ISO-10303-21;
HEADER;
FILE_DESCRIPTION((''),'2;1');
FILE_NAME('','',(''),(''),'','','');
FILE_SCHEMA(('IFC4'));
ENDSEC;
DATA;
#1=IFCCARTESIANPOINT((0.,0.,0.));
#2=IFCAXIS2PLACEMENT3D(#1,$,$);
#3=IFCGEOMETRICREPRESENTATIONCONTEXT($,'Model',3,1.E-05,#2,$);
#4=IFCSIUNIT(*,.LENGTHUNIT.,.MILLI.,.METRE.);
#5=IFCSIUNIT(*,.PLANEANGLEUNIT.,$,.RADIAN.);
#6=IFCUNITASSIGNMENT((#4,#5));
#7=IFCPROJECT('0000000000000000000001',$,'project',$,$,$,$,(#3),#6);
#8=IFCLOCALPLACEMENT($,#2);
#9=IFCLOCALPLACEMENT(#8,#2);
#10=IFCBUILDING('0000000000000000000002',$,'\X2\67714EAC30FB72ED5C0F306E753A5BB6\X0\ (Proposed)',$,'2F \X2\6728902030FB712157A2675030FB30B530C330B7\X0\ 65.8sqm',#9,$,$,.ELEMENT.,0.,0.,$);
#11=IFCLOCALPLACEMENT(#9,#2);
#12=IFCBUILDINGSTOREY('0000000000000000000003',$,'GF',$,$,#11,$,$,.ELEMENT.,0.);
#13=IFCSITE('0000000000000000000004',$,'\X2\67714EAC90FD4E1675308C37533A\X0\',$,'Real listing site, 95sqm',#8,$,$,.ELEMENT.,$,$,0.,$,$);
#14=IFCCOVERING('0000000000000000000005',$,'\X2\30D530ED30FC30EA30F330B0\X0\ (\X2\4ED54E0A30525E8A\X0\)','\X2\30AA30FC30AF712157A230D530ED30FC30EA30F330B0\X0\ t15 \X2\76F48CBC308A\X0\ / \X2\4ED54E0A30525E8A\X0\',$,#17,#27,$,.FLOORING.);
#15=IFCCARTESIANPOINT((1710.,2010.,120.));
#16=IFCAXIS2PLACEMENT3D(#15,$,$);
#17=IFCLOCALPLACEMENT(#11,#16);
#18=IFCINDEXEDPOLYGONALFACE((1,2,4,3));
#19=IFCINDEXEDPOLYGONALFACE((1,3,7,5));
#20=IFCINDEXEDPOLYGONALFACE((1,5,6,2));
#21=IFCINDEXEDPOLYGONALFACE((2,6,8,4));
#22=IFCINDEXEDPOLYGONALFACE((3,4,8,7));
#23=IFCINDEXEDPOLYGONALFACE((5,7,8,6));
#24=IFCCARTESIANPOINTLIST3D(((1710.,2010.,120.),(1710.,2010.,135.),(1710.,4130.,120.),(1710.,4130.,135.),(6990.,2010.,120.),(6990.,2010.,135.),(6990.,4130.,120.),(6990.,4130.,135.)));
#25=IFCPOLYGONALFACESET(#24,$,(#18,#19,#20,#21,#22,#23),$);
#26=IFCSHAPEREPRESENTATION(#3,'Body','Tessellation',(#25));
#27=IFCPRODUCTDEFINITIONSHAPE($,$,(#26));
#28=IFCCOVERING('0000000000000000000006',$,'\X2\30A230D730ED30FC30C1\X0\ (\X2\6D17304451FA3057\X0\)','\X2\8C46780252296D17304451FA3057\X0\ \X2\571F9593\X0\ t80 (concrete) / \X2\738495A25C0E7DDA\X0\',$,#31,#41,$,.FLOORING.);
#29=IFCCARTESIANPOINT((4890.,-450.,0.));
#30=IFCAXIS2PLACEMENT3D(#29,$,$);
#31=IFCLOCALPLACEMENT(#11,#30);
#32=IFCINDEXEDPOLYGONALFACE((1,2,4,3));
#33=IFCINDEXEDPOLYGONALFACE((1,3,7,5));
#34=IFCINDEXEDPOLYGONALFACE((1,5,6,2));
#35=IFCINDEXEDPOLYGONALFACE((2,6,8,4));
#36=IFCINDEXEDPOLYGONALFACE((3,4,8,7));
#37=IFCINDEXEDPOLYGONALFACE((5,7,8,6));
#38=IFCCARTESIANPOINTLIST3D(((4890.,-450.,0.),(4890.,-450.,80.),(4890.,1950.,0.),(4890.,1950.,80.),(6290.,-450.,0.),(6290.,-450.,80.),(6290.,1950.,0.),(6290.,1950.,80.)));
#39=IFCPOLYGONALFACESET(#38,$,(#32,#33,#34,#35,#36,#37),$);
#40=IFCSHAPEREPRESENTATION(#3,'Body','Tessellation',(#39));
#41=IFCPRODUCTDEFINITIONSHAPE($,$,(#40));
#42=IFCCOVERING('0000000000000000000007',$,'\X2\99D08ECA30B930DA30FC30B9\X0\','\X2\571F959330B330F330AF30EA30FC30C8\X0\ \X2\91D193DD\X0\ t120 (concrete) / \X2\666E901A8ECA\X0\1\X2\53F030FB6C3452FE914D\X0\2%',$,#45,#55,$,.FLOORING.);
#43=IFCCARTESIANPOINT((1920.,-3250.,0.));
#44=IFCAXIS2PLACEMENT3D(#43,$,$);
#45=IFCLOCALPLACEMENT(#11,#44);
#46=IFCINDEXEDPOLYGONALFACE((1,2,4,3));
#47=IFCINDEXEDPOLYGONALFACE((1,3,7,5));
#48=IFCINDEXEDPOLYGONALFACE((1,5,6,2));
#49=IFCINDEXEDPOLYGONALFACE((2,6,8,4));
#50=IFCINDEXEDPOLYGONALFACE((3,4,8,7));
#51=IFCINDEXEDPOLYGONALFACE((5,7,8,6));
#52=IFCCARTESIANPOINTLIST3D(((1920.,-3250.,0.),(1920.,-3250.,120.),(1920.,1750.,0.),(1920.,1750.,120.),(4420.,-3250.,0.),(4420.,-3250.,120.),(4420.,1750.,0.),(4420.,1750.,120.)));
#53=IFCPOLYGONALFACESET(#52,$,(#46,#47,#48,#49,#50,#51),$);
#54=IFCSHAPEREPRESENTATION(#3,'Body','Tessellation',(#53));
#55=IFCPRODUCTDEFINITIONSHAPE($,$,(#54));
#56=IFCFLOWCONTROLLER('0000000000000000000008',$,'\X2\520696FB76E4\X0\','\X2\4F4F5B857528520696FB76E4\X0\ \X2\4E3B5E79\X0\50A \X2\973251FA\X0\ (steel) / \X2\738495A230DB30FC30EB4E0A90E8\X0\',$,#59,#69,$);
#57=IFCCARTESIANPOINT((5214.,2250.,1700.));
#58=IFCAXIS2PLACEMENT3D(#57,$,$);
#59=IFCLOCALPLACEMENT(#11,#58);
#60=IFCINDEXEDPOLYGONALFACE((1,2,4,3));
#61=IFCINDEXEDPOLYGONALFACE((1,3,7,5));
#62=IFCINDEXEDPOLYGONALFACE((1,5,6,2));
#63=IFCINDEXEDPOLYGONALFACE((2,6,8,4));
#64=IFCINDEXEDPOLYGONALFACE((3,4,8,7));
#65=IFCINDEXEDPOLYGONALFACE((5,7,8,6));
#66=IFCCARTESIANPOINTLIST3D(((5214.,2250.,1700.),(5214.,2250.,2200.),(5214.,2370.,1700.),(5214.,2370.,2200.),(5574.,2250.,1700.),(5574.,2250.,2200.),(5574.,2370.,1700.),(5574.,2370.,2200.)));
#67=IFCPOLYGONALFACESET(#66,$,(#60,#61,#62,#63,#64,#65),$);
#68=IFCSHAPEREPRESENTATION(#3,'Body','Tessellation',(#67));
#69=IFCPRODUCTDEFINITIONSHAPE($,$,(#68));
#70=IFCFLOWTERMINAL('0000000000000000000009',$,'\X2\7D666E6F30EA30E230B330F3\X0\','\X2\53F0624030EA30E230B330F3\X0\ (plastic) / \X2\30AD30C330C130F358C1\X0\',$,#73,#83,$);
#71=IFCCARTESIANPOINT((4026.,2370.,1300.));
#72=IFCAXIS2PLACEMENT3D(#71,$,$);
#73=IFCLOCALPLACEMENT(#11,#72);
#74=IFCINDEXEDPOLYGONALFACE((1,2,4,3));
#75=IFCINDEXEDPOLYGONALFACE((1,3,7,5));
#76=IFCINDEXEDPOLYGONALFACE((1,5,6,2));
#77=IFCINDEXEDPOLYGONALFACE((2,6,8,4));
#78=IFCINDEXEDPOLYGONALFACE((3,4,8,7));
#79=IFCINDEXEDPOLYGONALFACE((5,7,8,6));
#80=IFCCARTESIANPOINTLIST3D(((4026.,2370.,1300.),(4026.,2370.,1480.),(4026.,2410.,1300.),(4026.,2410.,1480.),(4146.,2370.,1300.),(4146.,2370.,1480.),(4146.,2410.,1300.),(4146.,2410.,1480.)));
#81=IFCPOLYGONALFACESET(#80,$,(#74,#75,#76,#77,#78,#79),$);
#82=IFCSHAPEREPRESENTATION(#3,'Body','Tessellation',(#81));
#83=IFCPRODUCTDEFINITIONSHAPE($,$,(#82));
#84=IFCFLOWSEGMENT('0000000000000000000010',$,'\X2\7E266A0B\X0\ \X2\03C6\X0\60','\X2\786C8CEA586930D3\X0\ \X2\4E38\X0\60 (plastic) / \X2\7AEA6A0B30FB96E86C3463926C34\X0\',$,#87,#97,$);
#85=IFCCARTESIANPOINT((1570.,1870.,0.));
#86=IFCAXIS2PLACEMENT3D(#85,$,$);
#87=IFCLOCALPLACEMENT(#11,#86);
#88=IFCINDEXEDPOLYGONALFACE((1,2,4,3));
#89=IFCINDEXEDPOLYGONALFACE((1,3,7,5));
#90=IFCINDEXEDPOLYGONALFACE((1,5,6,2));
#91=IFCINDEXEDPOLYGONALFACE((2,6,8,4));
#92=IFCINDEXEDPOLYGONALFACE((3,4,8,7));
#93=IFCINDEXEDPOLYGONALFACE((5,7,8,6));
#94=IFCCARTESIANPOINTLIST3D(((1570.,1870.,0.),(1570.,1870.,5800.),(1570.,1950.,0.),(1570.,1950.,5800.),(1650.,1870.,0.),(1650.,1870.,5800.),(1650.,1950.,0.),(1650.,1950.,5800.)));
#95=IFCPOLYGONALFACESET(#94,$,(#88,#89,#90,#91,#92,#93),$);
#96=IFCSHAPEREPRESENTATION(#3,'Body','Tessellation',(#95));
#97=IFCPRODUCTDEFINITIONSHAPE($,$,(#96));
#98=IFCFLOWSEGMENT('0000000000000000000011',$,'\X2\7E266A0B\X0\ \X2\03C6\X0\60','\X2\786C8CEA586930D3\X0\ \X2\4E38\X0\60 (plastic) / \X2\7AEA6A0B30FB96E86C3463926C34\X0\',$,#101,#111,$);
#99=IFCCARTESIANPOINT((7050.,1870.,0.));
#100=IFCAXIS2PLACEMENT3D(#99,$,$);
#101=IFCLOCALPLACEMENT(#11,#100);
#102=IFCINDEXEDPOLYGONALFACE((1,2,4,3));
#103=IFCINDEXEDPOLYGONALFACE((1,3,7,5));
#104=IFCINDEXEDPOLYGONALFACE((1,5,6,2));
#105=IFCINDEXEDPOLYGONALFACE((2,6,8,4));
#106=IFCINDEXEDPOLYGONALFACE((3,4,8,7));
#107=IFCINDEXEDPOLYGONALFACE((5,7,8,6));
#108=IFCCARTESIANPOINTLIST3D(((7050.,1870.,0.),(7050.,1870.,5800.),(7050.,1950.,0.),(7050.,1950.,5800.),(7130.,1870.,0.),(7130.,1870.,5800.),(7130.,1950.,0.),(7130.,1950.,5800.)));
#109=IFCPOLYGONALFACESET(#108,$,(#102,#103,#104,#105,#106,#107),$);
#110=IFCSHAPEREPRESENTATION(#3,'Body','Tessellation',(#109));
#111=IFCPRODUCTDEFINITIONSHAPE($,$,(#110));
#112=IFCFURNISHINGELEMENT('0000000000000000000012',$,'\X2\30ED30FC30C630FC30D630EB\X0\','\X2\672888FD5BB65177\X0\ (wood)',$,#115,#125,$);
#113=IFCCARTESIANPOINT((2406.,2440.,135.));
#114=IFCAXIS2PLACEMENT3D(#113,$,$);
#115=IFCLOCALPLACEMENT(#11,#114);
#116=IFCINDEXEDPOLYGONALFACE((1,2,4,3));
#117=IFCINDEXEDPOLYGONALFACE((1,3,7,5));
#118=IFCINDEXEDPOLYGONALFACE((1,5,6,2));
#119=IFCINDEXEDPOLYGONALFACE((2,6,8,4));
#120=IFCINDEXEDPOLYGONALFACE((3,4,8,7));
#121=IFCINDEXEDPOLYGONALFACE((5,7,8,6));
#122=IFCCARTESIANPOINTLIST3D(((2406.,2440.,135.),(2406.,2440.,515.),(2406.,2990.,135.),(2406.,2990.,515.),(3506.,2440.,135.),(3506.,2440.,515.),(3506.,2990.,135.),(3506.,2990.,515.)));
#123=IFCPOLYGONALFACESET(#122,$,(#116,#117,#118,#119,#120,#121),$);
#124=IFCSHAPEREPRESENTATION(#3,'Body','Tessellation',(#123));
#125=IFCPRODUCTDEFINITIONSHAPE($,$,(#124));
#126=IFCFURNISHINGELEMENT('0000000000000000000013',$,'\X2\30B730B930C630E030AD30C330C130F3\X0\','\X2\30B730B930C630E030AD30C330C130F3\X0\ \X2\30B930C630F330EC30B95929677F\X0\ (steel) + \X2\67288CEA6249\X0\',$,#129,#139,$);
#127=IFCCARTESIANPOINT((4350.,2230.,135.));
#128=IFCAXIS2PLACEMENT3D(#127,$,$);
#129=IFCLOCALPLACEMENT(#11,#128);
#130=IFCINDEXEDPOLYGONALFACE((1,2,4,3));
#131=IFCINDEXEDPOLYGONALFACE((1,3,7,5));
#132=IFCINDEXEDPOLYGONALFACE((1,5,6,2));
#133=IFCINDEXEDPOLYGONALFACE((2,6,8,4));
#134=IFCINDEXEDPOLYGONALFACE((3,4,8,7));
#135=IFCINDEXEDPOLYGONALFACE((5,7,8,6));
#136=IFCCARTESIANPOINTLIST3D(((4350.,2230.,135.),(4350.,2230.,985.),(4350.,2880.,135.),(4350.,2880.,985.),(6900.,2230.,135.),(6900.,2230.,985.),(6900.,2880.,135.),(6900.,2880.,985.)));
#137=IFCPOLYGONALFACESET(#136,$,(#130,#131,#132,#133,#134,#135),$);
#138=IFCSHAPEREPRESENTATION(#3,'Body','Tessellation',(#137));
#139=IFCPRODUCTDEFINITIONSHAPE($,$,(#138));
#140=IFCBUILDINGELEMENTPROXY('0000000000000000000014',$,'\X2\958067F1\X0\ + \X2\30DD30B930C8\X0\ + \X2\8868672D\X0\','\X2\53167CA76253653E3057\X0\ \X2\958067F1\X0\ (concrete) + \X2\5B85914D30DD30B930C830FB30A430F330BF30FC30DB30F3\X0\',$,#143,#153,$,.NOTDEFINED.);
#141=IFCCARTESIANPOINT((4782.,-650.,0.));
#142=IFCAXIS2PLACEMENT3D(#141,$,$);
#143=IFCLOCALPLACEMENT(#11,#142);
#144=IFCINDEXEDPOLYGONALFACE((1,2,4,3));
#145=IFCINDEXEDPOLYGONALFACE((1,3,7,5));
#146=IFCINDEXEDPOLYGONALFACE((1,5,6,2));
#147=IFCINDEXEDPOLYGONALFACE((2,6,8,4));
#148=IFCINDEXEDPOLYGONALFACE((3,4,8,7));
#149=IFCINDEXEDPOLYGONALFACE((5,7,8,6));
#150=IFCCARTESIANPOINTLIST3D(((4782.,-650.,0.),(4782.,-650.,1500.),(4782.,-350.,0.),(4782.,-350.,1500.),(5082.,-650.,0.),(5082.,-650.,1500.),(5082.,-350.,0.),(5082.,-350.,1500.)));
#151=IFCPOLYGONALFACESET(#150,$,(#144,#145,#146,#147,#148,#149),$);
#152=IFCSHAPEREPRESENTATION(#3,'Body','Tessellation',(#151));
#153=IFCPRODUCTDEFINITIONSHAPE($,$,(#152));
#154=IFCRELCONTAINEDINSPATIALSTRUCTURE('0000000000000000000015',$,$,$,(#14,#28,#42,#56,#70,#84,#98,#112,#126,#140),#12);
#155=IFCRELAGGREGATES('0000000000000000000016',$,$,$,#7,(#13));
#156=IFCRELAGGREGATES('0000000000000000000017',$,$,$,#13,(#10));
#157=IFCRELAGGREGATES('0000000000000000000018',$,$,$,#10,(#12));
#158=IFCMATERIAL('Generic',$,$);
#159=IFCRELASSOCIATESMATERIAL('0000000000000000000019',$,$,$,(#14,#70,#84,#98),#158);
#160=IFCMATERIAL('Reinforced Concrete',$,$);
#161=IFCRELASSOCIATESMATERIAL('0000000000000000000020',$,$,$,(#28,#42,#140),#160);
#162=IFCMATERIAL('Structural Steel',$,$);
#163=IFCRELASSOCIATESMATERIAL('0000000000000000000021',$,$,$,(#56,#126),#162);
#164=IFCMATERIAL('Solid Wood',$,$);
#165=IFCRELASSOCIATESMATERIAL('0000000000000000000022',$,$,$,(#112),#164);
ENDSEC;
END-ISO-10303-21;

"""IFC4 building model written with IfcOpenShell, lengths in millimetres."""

from ifc_helpers import new_model, si_unit, frame, frame_2d, origin, place, context, project, spatial, rectangle, extrude, material, element, save


model = new_model("IFC4")

# Units and contexts
model_context = context("Model", 3, precision=1e-05, world=origin())
ifc_project = project(units=[si_unit("LENGTHUNIT", "METRE", prefix="MILLI"), si_unit("PLANEANGLEUNIT", "RADIAN")], contexts=[model_context])

# Site, building, storey
site_placement = place(None, origin())
site = spatial("IfcSite", under=ifc_project, at=site_placement, Name="東京都世田谷区", ObjectType="Real listing site, 95sqm", CompositionType="ELEMENT", RefElevation=0.0)
building_placement = place(site_placement, origin())
building = spatial("IfcBuilding", under=site, at=building_placement, Name="東京・狭小の町家 (Proposed)", ObjectType="2F 木造・無垢材・サッシ 65.8sqm", CompositionType="ELEMENT", ElevationOfRefHeight=0.0, ElevationOfTerrain=0.0)
storey_placement = place(building_placement, origin())
storey = spatial("IfcBuildingStorey", under=building, at=storey_placement, Name="GF", CompositionType="ELEMENT", Elevation=0.0)

# Shared definitions
ifc_material_1 = material(Name="Solid Wood")

# Shared definitions
ifc_material_2 = material(Name="Reinforced Concrete")

# Coverings
ifc_material_3 = material(Name="Generic")
covering_1_placement = place(storey_placement, frame((1710.0, 2010.0, 120.0)))
element("IfcCovering", 1, at=covering_1_placement, inside=storey, material=ifc_material_3, Name="フローリング (仕上げ床)", Description="オーク無垢フローリング t15 直貼り / 仕上げ床", PredefinedType="FLOORING", context=model_context, shape_type="SweptSolid", body=[
    extrude(rectangle(XDim=5280.0, YDim=2120.0, at=frame_2d((2640.0, 1060.0))), frame((1710.0, 2010.0, 120.0)), (0.0, 0.0, 1.0), 15.0),
])
covering_2_placement = place(storey_placement, frame((4890.0, -450.0, 0.0)))
element("IfcCovering", 2, at=covering_2_placement, inside=storey, material=ifc_material_2, Name="アプローチ (洗い出し)", Description="豆砂利洗い出し 土間 t80 (concrete) / 玄関導線", PredefinedType="FLOORING", context=model_context, shape_type="SweptSolid", body=[
    extrude(rectangle(XDim=1400.0, YDim=2400.0, at=frame_2d((700.0, 1200.0))), frame((4890.0, -450.0, 0.0)), (0.0, 0.0, 1.0), 80.0),
])
covering_3_placement = place(storey_placement, frame((1920.0, -3250.0, 0.0)))
element("IfcCovering", 3, at=covering_3_placement, inside=storey, material=ifc_material_2, Name="駐車スペース", Description="土間コンクリート 金鏝 t120 (concrete) / 普通車1台・水勾配2%", PredefinedType="FLOORING", context=model_context, shape_type="SweptSolid", body=[
    extrude(rectangle(XDim=2500.0, YDim=5000.0, at=frame_2d((1250.0, 2500.0))), frame((1920.0, -3250.0, 0.0)), (0.0, 0.0, 1.0), 120.0),
])

# Flow controller
ifc_material_4 = material(Name="Structural Steel")
flow_controller_placement = place(storey_placement, frame((5214.0, 2250.0, 1700.0)))
element("IfcFlowController", 4, at=flow_controller_placement, inside=storey, material=ifc_material_4, Name="分電盤", Description="住宅用分電盤 主幹50A 露出 (steel) / 玄関ホール上部", context=model_context, shape_type="SweptSolid", body=[
    extrude(rectangle(XDim=360.0, YDim=120.0, at=frame_2d((180.0, 60.0))), frame((5214.0, 2250.0, 1700.0)), (0.0, 0.0, 1.0), 500.0),
])

# Flow terminal
flow_terminal_placement = place(storey_placement, frame((4026.0, 2370.0, 1300.0)))
element("IfcFlowTerminal", 5, at=flow_terminal_placement, inside=storey, material=ifc_material_3, Name="給湯リモコン", Description="台所リモコン (plastic) / キッチン壁", context=model_context, shape_type="SweptSolid", body=[
    extrude(rectangle(XDim=120.0, YDim=40.0, at=frame_2d((60.0, 20.0))), frame((4026.0, 2370.0, 1300.0)), (0.0, 0.0, 1.0), 180.0),
])

# Flow segments
flow_segment_1_placement = place(storey_placement, frame((1570.0, 1870.0, 0.0)))
element("IfcFlowSegment", 6, at=flow_segment_1_placement, inside=storey, material=ifc_material_3, Name="縦樋 φ60", Description="硬質塩ビ 丸60 (plastic) / 竪樋・雨水排水", context=model_context, shape_type="SweptSolid", body=[
    extrude(rectangle(XDim=80.0, YDim=80.0, at=frame_2d((40.0, 40.0))), frame((1570.0, 1870.0, 0.0)), (0.0, 0.0, 1.0), 5800.0),
])
flow_segment_2_placement = place(storey_placement, frame((7050.0, 1870.0, 0.0)))
element("IfcFlowSegment", 7, at=flow_segment_2_placement, inside=storey, material=ifc_material_3, Name="縦樋 φ60", Description="硬質塩ビ 丸60 (plastic) / 竪樋・雨水排水", context=model_context, shape_type="SweptSolid", body=[
    extrude(rectangle(XDim=80.0, YDim=80.0, at=frame_2d((40.0, 40.0))), frame((7050.0, 1870.0, 0.0)), (0.0, 0.0, 1.0), 5800.0),
])

# Furnishing elements
furnishing_1_placement = place(storey_placement, frame((2406.0, 2440.0, 135.0)))
element("IfcFurnishingElement", 8, at=furnishing_1_placement, inside=storey, material=ifc_material_1, Name="ローテーブル", Description="木製家具 (wood)", context=model_context, shape_type="SweptSolid", body=[
    extrude(rectangle(XDim=1100.0, YDim=550.0, at=frame_2d((550.0, 275.0))), frame((2406.0, 2440.0, 135.0)), (0.0, 0.0, 1.0), 380.0),
])
furnishing_2_placement = place(storey_placement, frame((4350.0, 2230.0, 135.0)))
element("IfcFurnishingElement", 9, at=furnishing_2_placement, inside=storey, material=ifc_material_4, Name="システムキッチン", Description="システムキッチン ステンレス天板 (steel) + 木質扉", context=model_context, shape_type="SweptSolid", body=[
    extrude(rectangle(XDim=2550.0, YDim=650.0, at=frame_2d((1275.0, 325.0))), frame((4350.0, 2230.0, 135.0)), (0.0, 0.0, 1.0), 850.0),
])

# Building element proxy
proxy_placement = place(storey_placement, frame((4782.0, -650.0, 0.0)))
element("IfcBuildingElementProxy", 10, at=proxy_placement, inside=storey, material=ifc_material_2, Name="門柱 + ポスト + 表札", Description="化粧打放し 門柱 (concrete) + 宅配ポスト・インターホン", PredefinedType="NOTDEFINED", context=model_context, shape_type="SweptSolid", body=[
    extrude(rectangle(XDim=300.0, YDim=300.0, at=frame_2d((150.0, 150.0))), frame((4782.0, -650.0, 0.0)), (0.0, 0.0, 1.0), 1500.0),
])

save(model, "model.ifc")
